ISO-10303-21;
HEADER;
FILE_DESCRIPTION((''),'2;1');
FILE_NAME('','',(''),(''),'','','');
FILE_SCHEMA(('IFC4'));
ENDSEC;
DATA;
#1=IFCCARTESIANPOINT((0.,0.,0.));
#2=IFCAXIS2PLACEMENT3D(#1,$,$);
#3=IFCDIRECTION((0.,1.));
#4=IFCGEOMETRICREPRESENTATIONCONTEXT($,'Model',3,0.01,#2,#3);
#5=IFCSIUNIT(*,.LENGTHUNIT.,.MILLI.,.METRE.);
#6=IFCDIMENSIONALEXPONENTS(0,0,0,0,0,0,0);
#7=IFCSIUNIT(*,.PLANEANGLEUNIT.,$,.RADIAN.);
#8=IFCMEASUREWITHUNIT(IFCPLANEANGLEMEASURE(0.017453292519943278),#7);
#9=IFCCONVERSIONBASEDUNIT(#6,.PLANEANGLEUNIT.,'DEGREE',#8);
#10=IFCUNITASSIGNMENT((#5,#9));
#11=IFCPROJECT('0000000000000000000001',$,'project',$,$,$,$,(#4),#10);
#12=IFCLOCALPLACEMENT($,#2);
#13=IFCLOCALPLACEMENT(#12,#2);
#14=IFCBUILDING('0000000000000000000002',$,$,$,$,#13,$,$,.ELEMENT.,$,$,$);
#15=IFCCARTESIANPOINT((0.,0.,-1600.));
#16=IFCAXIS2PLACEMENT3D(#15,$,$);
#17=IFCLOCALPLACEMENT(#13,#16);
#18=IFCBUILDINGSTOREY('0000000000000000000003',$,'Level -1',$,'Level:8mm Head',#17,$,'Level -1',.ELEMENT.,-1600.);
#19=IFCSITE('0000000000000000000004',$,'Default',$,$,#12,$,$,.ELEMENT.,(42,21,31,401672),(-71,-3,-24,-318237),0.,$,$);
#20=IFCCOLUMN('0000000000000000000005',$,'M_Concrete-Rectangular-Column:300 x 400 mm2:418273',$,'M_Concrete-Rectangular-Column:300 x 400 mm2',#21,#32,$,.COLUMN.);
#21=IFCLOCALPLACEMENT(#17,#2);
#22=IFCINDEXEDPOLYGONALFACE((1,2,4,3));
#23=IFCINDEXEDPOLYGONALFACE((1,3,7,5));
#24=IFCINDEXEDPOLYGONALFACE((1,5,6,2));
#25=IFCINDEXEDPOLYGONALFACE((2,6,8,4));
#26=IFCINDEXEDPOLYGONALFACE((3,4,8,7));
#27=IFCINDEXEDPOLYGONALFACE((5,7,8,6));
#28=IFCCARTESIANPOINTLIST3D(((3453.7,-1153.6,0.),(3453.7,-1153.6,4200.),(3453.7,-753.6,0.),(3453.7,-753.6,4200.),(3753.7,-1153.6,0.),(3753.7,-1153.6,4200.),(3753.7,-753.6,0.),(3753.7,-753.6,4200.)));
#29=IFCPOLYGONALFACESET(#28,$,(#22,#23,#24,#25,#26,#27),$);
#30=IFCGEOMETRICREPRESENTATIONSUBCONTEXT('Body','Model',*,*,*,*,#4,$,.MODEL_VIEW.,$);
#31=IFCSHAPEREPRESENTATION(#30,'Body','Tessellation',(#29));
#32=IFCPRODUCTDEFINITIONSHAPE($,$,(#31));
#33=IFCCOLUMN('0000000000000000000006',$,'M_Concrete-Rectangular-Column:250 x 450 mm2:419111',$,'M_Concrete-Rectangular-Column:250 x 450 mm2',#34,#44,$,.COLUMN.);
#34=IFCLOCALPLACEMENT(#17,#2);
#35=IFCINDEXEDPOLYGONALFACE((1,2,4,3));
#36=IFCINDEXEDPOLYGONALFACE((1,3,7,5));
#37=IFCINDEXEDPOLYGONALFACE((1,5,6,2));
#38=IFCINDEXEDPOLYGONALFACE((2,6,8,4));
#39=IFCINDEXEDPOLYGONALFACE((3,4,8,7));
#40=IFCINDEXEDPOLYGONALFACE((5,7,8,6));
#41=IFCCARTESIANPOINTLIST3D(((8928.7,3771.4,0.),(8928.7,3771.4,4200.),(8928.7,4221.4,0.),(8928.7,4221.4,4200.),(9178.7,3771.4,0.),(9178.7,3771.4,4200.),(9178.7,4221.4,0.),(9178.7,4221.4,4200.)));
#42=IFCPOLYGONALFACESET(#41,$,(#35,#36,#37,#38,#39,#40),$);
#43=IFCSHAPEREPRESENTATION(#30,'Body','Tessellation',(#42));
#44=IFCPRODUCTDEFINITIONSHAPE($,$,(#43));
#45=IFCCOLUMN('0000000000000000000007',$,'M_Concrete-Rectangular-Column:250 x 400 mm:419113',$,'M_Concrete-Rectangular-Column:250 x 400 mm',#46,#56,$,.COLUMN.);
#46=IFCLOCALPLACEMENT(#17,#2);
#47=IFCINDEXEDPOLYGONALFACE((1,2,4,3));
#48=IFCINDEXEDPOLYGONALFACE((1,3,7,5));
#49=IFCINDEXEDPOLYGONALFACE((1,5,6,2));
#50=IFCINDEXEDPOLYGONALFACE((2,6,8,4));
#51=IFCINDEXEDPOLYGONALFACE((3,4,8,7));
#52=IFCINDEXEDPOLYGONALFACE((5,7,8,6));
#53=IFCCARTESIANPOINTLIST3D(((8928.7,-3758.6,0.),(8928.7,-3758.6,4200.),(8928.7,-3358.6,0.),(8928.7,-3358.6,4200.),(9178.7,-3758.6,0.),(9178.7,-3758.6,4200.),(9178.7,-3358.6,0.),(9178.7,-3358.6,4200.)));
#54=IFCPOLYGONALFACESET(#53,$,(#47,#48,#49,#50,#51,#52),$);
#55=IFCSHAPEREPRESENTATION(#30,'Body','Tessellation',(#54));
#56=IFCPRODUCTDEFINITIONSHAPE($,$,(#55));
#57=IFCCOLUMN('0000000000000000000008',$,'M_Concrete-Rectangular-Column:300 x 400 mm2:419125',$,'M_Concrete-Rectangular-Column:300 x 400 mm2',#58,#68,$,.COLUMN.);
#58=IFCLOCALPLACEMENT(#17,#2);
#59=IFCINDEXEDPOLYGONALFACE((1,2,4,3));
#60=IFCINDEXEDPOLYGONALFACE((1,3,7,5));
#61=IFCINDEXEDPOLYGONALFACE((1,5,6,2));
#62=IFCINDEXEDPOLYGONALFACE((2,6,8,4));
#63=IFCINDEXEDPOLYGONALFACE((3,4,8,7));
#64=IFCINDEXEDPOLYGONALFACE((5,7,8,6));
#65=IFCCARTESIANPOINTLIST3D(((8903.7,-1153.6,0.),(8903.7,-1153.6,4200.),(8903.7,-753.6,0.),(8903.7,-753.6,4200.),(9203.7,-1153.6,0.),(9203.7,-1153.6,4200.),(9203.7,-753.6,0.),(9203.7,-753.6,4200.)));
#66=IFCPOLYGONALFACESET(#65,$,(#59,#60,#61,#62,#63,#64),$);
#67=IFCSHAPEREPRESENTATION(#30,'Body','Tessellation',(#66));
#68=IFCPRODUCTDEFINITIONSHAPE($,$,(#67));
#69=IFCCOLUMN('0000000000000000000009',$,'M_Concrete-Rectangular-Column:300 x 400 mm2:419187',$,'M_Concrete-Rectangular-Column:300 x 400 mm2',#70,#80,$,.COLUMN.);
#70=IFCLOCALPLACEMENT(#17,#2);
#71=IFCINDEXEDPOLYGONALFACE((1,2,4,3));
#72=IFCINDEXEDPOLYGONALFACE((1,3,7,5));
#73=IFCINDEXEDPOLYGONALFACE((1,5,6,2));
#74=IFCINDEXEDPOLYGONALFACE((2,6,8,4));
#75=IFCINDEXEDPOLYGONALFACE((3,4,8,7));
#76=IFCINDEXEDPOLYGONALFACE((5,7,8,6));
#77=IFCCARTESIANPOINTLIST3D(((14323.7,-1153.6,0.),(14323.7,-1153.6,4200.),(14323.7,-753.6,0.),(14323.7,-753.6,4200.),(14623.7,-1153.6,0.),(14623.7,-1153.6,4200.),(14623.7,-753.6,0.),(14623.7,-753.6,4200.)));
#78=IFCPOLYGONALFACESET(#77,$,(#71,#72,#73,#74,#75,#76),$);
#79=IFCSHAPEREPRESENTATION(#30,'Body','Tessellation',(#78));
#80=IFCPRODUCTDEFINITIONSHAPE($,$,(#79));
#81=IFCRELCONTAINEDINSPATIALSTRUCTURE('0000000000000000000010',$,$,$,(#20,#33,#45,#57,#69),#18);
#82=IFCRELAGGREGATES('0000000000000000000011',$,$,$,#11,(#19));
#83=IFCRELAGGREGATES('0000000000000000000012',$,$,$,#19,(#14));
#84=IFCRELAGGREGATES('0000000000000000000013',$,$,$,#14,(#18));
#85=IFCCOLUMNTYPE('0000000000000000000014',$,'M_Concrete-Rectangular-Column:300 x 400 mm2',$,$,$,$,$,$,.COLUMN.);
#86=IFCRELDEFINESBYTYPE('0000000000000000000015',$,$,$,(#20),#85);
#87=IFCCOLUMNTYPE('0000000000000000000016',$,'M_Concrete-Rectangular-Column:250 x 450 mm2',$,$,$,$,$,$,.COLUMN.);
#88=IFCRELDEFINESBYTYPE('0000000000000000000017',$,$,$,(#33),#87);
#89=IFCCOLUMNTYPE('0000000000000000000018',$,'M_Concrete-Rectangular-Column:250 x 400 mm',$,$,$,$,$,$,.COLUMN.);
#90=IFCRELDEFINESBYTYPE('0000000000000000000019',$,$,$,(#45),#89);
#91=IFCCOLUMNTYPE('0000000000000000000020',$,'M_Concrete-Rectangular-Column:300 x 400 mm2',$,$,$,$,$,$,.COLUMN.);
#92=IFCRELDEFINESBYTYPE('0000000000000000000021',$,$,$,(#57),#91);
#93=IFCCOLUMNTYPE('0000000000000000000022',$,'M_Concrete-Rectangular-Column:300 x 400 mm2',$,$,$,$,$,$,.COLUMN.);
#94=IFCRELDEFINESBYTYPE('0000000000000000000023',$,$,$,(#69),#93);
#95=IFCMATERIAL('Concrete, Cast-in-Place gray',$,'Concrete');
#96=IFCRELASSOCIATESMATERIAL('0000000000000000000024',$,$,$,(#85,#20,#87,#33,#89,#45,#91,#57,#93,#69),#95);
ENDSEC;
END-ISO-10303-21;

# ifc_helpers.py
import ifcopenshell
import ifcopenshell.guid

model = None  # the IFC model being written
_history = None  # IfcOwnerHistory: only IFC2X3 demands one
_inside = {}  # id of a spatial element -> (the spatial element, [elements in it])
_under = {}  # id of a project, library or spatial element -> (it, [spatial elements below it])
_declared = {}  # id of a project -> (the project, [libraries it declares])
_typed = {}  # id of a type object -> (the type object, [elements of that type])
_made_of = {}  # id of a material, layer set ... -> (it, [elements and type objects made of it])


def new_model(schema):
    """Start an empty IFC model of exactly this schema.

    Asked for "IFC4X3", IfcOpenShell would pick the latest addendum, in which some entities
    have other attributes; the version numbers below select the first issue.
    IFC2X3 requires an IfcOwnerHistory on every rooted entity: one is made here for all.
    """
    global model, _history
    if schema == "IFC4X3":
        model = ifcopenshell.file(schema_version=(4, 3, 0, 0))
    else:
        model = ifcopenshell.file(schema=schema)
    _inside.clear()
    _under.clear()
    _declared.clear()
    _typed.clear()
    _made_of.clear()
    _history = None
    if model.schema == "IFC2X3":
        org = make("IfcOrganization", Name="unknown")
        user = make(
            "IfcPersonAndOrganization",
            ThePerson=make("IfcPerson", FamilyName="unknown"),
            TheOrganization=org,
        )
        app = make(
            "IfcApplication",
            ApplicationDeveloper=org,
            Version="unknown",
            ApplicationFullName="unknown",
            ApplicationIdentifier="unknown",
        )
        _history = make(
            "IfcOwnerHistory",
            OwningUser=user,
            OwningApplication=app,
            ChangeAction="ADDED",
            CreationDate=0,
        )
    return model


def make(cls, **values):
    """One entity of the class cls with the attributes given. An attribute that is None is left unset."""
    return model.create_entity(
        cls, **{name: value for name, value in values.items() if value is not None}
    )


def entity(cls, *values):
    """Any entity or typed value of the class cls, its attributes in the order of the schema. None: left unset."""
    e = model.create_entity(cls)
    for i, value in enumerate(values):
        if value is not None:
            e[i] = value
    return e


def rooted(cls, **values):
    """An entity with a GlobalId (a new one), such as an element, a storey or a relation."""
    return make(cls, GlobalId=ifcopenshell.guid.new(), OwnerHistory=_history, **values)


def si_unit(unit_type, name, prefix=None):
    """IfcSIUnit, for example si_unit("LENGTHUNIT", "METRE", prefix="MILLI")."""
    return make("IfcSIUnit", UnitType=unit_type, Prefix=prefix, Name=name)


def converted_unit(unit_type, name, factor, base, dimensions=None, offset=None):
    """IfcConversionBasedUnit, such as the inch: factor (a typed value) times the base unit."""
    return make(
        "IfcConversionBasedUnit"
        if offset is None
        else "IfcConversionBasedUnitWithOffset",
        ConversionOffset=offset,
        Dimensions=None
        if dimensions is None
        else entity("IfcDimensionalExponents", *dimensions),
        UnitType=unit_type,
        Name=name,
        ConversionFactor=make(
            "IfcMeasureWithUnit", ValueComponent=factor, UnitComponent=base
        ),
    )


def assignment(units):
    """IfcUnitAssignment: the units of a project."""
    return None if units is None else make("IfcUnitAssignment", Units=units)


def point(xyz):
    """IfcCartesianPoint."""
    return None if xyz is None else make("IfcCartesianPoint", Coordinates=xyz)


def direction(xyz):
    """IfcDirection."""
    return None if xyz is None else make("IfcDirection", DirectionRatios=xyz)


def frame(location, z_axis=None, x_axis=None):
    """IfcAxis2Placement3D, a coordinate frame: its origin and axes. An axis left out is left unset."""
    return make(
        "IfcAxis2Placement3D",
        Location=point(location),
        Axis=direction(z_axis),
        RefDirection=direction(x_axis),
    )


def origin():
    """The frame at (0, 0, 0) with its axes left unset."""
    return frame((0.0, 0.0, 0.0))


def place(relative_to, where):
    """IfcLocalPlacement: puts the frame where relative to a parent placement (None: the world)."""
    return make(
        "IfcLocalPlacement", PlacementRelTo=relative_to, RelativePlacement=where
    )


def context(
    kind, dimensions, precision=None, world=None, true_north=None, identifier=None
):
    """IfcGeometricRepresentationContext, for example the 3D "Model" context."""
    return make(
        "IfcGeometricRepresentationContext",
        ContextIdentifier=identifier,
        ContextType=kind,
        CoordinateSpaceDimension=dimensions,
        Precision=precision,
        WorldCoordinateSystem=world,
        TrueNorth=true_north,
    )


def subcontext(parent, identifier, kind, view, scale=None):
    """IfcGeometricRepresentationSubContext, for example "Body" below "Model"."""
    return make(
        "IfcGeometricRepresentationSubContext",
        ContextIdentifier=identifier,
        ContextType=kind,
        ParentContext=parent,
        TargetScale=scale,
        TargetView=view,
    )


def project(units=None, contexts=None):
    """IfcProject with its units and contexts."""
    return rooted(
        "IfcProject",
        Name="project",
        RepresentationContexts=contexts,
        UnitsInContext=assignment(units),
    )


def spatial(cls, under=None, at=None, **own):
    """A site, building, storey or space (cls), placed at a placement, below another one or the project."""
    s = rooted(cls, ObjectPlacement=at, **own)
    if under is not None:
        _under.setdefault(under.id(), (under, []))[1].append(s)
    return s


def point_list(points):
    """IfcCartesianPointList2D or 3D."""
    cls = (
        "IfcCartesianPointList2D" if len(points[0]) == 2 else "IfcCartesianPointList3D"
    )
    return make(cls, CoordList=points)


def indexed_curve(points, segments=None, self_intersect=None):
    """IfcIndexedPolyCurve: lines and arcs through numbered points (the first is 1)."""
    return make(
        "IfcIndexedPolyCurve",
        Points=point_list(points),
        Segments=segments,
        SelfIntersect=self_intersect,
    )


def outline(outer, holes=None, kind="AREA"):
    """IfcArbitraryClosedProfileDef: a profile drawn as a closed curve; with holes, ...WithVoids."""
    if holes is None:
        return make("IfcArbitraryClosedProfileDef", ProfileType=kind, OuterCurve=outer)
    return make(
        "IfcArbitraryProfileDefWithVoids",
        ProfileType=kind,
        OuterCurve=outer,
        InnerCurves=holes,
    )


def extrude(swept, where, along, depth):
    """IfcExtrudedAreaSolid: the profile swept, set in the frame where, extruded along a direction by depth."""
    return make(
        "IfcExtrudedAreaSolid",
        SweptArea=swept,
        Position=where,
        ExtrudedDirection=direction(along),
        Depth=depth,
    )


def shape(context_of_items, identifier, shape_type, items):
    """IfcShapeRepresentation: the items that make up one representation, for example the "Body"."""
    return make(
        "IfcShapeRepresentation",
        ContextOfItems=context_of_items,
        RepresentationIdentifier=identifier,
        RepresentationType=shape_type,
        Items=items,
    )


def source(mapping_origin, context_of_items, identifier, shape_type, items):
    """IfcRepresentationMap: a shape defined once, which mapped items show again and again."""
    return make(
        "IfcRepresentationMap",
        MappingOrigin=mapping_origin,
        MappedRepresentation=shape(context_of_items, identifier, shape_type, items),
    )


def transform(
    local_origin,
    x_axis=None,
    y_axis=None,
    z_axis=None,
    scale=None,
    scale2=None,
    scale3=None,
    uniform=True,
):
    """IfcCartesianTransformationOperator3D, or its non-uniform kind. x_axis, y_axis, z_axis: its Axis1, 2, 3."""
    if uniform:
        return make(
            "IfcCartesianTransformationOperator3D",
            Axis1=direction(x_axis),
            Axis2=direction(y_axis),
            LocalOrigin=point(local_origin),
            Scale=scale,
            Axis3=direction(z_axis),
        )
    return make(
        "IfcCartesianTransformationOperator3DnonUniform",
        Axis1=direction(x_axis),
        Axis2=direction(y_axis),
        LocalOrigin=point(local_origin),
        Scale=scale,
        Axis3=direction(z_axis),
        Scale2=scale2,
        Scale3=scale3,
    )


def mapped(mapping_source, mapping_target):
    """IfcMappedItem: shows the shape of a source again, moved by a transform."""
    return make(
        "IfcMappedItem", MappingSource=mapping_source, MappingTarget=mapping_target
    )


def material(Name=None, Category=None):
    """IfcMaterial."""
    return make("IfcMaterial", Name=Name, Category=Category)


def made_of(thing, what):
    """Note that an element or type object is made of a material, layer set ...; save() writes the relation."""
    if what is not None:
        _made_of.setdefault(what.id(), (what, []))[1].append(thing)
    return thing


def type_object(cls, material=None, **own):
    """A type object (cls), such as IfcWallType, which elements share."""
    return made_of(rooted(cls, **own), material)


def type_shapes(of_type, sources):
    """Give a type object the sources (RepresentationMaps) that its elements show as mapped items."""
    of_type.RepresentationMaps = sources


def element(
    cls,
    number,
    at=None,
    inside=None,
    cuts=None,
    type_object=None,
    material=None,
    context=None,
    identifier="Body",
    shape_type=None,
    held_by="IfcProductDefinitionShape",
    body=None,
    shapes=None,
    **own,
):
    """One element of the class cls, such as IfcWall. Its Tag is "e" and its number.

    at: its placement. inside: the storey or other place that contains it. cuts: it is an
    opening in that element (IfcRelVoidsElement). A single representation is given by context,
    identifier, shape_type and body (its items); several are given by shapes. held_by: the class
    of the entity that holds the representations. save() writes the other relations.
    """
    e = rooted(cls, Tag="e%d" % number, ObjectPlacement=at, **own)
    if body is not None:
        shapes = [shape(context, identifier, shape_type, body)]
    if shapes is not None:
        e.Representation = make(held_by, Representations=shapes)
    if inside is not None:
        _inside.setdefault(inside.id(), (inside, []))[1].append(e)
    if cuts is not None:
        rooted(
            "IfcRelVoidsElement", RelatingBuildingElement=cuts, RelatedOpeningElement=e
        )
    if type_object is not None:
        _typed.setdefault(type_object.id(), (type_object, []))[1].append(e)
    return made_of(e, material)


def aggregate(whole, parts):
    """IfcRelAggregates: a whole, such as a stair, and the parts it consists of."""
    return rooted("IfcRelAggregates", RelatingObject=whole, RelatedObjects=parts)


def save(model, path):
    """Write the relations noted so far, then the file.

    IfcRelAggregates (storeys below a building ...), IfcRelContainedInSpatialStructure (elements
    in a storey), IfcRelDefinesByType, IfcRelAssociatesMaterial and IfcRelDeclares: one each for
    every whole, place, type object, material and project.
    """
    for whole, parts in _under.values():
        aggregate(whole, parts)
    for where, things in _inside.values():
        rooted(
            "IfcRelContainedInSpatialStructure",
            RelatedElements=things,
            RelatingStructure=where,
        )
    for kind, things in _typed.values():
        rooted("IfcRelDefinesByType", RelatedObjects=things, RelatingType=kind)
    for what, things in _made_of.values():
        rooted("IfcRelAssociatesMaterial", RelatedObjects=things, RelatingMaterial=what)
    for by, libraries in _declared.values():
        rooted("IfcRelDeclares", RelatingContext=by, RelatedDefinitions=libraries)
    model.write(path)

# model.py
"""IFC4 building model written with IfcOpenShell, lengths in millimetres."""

from ifc_helpers import new_model, entity, si_unit, converted_unit, direction, frame, origin, place, context, subcontext, project, spatial, indexed_curve, outline, extrude, source, transform, mapped, material, type_object, type_shapes, element, save


model = new_model("IFC4")

# Units and contexts
model_context = context("Model", 3, precision=0.01, world=origin(), true_north=direction((0.0, 1.0)))
body_context = subcontext(model_context, "Body", "Model", "MODEL_VIEW")
ifc_project = project(units=[si_unit("LENGTHUNIT", "METRE", prefix="MILLI"), converted_unit("PLANEANGLEUNIT", "DEGREE", entity("IfcPlaneAngleMeasure", 0.017453292519943278), si_unit("PLANEANGLEUNIT", "RADIAN"), dimensions=[0, 0, 0, 0, 0, 0, 0])], contexts=[model_context])

# Site, building, storey
site_placement = place(None, origin())
site = spatial("IfcSite", under=ifc_project, at=site_placement, Name="Default", CompositionType="ELEMENT", RefLatitude=(42, 21, 31, 401672), RefLongitude=(-71, -3, -24, -318237), RefElevation=0.0)
building_placement = place(site_placement, origin())
building = spatial("IfcBuilding", under=site, at=building_placement, CompositionType="ELEMENT")
storey_placement = place(building_placement, frame((0.0, 0.0, -1600.0)))
storey = spatial("IfcBuildingStorey", under=building, at=storey_placement, Name="Level -1", ObjectType="Level:8mm Head", LongName="Level -1", CompositionType="ELEMENT", Elevation=-1600.0)

# Shared definitions
ifc_material = material(Name="Concrete, Cast-in-Place gray", Category="Concrete")

# Columns
column_type_1 = type_object("IfcColumnType", Name="M_Concrete-Rectangular-Column:300 x 400 mm2", PredefinedType="COLUMN", material=ifc_material)
shared_shape_1 = source(origin(), body_context, "Body", "SweptSolid", [
    extrude(outline(indexed_curve([(-2100.0, -200.0), (2100.0, -200.0), (2100.0, 200.0), (-2100.0, 200.0), (-2100.0, -200.0)], self_intersect=False)), frame((3453.7, -953.6, 500.0), z_axis=(1.0, 0.0, 0.0), x_axis=(0.0, 0.0, 1.0)), (0.0, 0.0, 1.0), 300.0),
])
type_shapes(column_type_1, [shared_shape_1])
column_1_placement = place(storey_placement, frame((0.0, 0.0, 1600.0)))
element("IfcColumn", 1, at=column_1_placement, inside=storey, type_object=column_type_1, material=ifc_material, Name="M_Concrete-Rectangular-Column:300 x 400 mm2:418273", ObjectType="M_Concrete-Rectangular-Column:300 x 400 mm2", PredefinedType="COLUMN", context=body_context, shape_type="MappedRepresentation", body=[
    mapped(shared_shape_1, transform((0.0, 0.0, 0.0), scale=1.0)),
])
column_type_2 = type_object("IfcColumnType", Name="M_Concrete-Rectangular-Column:250 x 450 mm2", PredefinedType="COLUMN", material=ifc_material)
shared_shape_2 = source(origin(), body_context, "Body", "SweptSolid", [
    extrude(outline(indexed_curve([(-2100.0, -225.0), (2100.0, -225.0), (2100.0, 225.0), (-2100.0, 225.0), (-2100.0, -225.0)], self_intersect=False)), frame((8928.7, 3996.4, 500.0), z_axis=(1.0, 0.0, 0.0), x_axis=(0.0, 0.0, 1.0)), (0.0, 0.0, 1.0), 250.0),
])
type_shapes(column_type_2, [shared_shape_2])
column_2_placement = place(storey_placement, frame((0.0, 0.0, 1600.0)))
element("IfcColumn", 2, at=column_2_placement, inside=storey, type_object=column_type_2, material=ifc_material, Name="M_Concrete-Rectangular-Column:250 x 450 mm2:419111", ObjectType="M_Concrete-Rectangular-Column:250 x 450 mm2", PredefinedType="COLUMN", context=body_context, shape_type="MappedRepresentation", body=[
    mapped(shared_shape_2, transform((0.0, 0.0, 0.0), scale=1.0)),
])
column_type_3 = type_object("IfcColumnType", Name="M_Concrete-Rectangular-Column:250 x 400 mm", PredefinedType="COLUMN", material=ifc_material)
shared_shape_3 = source(origin(), body_context, "Body", "SweptSolid", [
    extrude(outline(indexed_curve([(-2100.0, -200.0), (2100.0, -200.0), (2100.0, 200.0), (-2100.0, 200.0), (-2100.0, -200.0)], self_intersect=False)), frame((8928.7, -3558.6, 500.0), z_axis=(1.0, 0.0, 0.0), x_axis=(0.0, 0.0, 1.0)), (0.0, 0.0, 1.0), 250.0),
])
type_shapes(column_type_3, [shared_shape_3])
column_3_placement = place(storey_placement, frame((0.0, 0.0, 1600.0)))
element("IfcColumn", 3, at=column_3_placement, inside=storey, type_object=column_type_3, material=ifc_material, Name="M_Concrete-Rectangular-Column:250 x 400 mm:419113", ObjectType="M_Concrete-Rectangular-Column:250 x 400 mm", PredefinedType="COLUMN", context=body_context, shape_type="MappedRepresentation", body=[
    mapped(shared_shape_3, transform((0.0, 0.0, 0.0), scale=1.0)),
])
column_type_4 = type_object("IfcColumnType", Name="M_Concrete-Rectangular-Column:300 x 400 mm2", PredefinedType="COLUMN", material=ifc_material)
shared_shape_4 = source(origin(), body_context, "Body", "SweptSolid", [
    extrude(outline(indexed_curve([(-2100.0, -200.0), (2100.0, -200.0), (2100.0, 200.0), (-2100.0, 200.0), (-2100.0, -200.0)], self_intersect=False)), frame((8903.7, -953.6, 500.0), z_axis=(1.0, 0.0, 0.0), x_axis=(0.0, 0.0, 1.0)), (0.0, 0.0, 1.0), 300.0),
])
type_shapes(column_type_4, [shared_shape_4])
column_4_placement = place(storey_placement, frame((0.0, 0.0, 1600.0)))
element("IfcColumn", 4, at=column_4_placement, inside=storey, type_object=column_type_4, material=ifc_material, Name="M_Concrete-Rectangular-Column:300 x 400 mm2:419125", ObjectType="M_Concrete-Rectangular-Column:300 x 400 mm2", PredefinedType="COLUMN", context=body_context, shape_type="MappedRepresentation", body=[
    mapped(shared_shape_4, transform((0.0, 0.0, 0.0), scale=1.0)),
])
column_type_5 = type_object("IfcColumnType", Name="M_Concrete-Rectangular-Column:300 x 400 mm2", PredefinedType="COLUMN", material=ifc_material)
shared_shape_5 = source(origin(), body_context, "Body", "SweptSolid", [
    extrude(outline(indexed_curve([(-2100.0, -200.0), (2100.0, -200.0), (2100.0, 200.0), (-2100.0, 200.0), (-2100.0, -200.0)], self_intersect=False)), frame((14323.7, -953.6, 500.0), z_axis=(1.0, 0.0, 0.0), x_axis=(0.0, 0.0, 1.0)), (0.0, 0.0, 1.0), 300.0),
])
type_shapes(column_type_5, [shared_shape_5])
column_5_placement = place(storey_placement, frame((0.0, 0.0, 1600.0)))
element("IfcColumn", 5, at=column_5_placement, inside=storey, type_object=column_type_5, material=ifc_material, Name="M_Concrete-Rectangular-Column:300 x 400 mm2:419187", ObjectType="M_Concrete-Rectangular-Column:300 x 400 mm2", PredefinedType="COLUMN", context=body_context, shape_type="MappedRepresentation", body=[
    mapped(shared_shape_5, transform((0.0, 0.0, 0.0), scale=1.0)),
])

save(model, "model.ifc")
